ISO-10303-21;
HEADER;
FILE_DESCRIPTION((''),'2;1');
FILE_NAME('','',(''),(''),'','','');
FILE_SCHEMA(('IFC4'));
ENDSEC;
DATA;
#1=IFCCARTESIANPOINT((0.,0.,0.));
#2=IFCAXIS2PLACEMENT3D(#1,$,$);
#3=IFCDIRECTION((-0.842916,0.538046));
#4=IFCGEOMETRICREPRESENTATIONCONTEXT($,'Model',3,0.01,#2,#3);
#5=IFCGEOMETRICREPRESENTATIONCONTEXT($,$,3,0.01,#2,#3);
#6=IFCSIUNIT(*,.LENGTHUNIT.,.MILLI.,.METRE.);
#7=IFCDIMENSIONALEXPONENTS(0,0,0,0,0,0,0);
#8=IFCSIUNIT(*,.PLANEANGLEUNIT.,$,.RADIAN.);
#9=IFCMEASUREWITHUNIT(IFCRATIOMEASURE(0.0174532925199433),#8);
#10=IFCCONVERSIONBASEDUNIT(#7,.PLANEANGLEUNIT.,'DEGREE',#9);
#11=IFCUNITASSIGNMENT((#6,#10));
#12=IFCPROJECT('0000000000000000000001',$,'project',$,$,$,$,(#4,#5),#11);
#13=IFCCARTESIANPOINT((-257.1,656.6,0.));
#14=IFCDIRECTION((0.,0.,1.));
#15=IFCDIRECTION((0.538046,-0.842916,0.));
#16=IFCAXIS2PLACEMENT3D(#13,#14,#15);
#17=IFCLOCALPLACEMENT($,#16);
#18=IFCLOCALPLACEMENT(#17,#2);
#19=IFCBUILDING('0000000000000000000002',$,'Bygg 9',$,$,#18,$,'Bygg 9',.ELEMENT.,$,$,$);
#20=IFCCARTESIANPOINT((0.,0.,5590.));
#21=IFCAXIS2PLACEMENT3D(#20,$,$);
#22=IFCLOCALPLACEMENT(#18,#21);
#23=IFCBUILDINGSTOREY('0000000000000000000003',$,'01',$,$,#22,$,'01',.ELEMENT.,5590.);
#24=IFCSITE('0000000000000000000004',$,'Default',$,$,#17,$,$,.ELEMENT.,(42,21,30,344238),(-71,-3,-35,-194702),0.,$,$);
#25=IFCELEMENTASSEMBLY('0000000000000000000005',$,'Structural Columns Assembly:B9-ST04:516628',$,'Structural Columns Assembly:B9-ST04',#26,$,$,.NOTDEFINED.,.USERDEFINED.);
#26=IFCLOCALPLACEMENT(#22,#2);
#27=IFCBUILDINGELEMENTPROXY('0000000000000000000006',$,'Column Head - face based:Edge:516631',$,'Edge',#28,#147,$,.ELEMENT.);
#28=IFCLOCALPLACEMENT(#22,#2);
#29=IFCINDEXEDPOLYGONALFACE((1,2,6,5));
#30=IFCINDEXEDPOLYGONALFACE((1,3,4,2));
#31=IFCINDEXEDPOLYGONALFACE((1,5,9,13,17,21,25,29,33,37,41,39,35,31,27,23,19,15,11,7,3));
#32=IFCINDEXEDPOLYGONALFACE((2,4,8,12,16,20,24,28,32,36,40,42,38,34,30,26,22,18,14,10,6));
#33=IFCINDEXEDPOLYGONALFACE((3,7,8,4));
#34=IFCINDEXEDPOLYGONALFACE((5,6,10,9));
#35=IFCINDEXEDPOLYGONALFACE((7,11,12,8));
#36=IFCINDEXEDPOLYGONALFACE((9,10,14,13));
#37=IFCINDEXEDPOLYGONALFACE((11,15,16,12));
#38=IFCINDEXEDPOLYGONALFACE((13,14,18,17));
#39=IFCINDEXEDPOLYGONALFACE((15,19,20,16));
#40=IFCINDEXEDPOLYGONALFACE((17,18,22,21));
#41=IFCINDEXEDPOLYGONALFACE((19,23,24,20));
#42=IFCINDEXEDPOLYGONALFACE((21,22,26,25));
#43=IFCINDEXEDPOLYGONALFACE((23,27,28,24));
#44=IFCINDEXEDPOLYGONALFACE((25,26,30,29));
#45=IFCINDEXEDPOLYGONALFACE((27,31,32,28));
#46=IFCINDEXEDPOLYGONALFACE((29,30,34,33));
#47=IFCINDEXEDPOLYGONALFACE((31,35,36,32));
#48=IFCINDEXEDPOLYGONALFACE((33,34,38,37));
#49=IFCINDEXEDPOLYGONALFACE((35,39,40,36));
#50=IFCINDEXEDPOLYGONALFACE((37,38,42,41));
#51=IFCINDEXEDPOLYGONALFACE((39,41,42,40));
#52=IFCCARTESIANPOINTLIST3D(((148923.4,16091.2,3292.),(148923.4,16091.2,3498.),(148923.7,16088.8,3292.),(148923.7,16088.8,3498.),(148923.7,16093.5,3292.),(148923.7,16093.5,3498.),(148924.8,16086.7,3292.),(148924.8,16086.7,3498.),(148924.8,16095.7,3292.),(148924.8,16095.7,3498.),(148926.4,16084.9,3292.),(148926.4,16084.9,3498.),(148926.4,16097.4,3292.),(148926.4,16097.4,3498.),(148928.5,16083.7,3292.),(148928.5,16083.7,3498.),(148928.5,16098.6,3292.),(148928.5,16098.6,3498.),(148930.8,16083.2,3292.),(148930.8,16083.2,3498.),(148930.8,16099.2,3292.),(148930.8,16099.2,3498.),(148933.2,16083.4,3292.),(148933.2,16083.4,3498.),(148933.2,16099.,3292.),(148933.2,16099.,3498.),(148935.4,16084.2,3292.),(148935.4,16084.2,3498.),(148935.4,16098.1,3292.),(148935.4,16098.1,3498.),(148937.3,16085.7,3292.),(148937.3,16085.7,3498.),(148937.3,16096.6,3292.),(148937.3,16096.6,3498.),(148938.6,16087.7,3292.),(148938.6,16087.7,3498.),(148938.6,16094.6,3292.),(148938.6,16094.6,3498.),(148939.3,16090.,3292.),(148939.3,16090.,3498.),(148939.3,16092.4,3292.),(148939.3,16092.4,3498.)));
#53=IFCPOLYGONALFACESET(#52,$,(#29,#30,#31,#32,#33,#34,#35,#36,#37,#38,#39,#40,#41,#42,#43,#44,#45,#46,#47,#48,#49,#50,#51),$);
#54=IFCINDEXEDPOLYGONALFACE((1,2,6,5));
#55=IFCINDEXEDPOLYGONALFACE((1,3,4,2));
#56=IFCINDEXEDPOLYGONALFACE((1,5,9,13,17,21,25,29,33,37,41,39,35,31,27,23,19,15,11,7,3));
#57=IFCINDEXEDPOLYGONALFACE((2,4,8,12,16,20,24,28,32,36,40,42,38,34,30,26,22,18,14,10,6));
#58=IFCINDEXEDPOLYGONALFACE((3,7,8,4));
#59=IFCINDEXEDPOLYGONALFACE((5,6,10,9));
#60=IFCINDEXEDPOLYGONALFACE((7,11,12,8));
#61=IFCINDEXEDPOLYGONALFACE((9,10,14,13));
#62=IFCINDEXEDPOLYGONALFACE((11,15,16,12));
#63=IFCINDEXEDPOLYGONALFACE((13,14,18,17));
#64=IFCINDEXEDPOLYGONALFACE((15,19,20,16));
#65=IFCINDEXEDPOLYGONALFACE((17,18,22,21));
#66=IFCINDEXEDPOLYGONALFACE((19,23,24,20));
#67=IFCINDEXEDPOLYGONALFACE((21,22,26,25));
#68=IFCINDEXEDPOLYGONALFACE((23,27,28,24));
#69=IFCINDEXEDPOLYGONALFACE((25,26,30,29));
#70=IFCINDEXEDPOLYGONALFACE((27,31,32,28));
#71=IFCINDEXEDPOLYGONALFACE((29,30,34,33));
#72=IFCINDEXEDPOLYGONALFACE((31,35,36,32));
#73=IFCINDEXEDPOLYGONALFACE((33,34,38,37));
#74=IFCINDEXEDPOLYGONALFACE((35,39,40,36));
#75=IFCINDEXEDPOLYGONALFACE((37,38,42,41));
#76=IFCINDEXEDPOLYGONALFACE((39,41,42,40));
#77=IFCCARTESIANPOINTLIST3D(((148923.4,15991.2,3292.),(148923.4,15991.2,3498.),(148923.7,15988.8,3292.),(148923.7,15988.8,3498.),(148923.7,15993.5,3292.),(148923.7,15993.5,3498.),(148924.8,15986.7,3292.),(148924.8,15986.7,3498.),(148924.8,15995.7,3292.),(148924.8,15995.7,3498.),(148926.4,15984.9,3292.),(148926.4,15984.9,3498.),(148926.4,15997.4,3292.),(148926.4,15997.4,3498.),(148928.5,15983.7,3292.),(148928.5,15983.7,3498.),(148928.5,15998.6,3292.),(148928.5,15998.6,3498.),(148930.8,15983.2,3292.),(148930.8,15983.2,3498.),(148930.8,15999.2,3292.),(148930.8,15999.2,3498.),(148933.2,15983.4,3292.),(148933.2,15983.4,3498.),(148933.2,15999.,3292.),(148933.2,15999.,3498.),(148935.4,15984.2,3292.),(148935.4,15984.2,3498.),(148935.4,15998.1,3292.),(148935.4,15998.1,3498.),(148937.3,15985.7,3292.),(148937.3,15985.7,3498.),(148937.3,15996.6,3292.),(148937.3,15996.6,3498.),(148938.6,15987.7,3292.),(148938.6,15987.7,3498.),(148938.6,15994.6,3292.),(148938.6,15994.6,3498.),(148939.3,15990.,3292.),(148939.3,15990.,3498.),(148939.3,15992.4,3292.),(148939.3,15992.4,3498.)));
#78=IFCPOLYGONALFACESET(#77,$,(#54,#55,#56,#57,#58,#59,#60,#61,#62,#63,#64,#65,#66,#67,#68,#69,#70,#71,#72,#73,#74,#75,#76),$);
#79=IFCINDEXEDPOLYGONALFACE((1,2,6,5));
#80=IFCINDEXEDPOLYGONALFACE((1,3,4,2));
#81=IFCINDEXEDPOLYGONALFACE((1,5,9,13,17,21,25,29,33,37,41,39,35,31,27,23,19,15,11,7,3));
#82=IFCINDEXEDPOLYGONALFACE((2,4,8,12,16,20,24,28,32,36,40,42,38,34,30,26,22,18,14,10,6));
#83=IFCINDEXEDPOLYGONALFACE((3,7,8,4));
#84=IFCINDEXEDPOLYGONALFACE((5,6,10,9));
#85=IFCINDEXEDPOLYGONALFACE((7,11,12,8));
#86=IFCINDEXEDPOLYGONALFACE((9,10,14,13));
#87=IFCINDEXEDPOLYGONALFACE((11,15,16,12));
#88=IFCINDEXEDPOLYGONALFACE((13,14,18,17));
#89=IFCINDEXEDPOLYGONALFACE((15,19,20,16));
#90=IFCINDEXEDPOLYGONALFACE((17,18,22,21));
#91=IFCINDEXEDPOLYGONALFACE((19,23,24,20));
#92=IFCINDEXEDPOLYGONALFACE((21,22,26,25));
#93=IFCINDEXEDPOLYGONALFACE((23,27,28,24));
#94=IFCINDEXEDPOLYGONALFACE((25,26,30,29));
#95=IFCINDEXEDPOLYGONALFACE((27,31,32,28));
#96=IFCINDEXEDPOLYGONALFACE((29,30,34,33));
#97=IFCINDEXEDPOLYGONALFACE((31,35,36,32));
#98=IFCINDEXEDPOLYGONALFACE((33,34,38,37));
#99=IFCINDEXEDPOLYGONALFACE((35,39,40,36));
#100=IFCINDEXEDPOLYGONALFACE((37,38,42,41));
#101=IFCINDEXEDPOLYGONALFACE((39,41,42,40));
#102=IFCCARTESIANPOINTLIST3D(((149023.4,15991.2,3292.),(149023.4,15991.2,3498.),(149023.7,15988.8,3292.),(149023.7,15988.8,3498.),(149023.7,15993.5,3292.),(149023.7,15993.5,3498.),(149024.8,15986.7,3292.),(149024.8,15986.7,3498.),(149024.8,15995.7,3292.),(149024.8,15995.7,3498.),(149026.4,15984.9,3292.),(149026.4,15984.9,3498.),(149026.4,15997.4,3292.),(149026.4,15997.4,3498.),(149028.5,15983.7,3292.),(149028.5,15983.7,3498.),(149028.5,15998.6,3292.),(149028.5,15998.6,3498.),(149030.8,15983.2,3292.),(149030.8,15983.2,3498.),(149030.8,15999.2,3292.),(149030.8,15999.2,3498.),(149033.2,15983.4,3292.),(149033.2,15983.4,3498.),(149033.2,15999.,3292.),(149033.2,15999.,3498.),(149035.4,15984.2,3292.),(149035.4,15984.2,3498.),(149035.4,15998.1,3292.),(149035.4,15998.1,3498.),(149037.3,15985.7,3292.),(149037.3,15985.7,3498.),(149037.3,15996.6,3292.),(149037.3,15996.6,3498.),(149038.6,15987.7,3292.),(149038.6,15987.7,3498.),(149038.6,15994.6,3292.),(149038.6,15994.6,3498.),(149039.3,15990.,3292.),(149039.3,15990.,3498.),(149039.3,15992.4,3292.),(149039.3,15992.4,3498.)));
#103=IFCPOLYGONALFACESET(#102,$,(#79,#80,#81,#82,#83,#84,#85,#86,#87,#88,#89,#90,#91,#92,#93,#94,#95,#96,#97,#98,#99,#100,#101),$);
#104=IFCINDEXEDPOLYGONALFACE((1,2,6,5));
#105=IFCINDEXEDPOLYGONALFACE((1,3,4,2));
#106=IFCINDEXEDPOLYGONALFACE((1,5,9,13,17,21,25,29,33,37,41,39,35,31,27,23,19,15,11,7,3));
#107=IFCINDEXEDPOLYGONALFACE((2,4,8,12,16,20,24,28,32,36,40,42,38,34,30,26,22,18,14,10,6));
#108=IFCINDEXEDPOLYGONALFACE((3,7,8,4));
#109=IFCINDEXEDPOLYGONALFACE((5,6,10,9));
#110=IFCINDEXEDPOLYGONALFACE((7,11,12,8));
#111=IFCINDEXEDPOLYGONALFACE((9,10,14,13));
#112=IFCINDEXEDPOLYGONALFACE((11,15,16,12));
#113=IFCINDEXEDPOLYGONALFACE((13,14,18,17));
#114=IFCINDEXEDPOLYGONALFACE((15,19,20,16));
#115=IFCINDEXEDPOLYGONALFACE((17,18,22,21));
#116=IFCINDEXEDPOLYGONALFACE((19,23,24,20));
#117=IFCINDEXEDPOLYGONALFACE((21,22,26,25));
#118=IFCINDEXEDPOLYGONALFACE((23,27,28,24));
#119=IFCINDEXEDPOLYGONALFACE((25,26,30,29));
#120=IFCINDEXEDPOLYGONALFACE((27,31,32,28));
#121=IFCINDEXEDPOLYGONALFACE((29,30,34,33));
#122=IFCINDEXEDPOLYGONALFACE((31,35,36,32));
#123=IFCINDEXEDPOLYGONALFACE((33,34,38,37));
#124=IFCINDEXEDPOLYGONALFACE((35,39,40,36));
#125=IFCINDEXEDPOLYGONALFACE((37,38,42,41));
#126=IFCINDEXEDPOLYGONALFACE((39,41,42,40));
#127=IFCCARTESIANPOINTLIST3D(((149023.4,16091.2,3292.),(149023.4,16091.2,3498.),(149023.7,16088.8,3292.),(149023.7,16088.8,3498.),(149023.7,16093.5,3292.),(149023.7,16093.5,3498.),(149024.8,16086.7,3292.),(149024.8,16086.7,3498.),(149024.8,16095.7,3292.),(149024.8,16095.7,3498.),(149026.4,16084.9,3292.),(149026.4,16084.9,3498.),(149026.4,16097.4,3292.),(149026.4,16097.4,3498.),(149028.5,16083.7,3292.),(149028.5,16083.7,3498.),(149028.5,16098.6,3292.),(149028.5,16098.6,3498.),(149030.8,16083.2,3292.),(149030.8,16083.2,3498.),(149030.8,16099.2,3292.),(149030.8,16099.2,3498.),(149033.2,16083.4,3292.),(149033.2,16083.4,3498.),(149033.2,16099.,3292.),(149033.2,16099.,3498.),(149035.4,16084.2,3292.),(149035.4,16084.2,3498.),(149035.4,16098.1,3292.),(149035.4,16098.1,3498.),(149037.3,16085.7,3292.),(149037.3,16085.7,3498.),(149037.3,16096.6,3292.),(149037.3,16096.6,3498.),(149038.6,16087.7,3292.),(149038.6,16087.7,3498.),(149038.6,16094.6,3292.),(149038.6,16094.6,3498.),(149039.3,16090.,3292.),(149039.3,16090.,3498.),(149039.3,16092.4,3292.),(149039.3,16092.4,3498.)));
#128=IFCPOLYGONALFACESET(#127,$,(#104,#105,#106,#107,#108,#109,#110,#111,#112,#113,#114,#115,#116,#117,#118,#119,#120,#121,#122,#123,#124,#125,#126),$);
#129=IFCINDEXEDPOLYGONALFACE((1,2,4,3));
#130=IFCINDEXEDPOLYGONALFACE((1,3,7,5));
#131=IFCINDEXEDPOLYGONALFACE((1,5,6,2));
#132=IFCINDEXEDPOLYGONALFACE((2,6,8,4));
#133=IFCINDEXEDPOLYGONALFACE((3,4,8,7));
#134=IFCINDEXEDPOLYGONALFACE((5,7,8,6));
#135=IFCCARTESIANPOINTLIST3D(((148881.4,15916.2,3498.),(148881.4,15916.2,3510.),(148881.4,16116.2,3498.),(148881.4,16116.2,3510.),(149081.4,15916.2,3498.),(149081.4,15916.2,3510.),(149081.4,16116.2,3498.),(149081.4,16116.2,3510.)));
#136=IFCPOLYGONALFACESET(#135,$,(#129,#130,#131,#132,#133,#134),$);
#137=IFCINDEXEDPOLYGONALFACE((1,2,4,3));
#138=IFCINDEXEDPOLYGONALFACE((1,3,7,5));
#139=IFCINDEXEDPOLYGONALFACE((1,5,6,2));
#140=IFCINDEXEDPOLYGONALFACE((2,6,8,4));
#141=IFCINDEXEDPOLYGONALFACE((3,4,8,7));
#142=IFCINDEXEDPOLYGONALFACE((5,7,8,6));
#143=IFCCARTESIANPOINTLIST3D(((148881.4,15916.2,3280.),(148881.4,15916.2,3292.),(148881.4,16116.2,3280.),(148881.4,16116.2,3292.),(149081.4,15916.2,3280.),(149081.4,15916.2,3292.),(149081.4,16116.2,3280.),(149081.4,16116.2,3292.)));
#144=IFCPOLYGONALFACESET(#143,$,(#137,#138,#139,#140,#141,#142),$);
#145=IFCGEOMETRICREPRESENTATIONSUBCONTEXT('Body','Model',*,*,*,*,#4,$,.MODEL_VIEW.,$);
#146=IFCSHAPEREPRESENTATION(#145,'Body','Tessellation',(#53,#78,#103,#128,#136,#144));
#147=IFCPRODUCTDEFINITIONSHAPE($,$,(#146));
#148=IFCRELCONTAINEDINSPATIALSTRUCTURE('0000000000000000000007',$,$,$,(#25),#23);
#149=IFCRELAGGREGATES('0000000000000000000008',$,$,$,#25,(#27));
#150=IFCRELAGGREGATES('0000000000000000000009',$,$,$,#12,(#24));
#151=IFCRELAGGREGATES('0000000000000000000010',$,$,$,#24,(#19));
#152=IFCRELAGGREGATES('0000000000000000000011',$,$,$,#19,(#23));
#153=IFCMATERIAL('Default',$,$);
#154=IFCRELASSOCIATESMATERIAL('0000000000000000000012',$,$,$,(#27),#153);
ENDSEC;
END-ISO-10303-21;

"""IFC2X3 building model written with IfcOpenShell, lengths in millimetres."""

from ifc_helpers import new_model, entity, si_unit, converted_unit, direction, frame, frame_2d, origin, origin_2d_with_axis, place, context, subcontext, project, spatial, rectangle, circle, extrude, source, transform, mapped, material, element, aggregate, save


model = new_model("IFC2X3")

# Units and contexts
model_context = context("Model", 3, precision=0.01, world=origin(), true_north=direction((-0.842916, 0.538046)))
context_of_model = context(None, 3, precision=0.01, world=origin(), true_north=direction((-0.842916, 0.538046)))
body_context = subcontext(model_context, "Body", "Model", "MODEL_VIEW")
ifc_project = project(units=[si_unit("LENGTHUNIT", "METRE", prefix="MILLI"), converted_unit("PLANEANGLEUNIT", "DEGREE", entity("IfcRatioMeasure", 0.0174532925199433), si_unit("PLANEANGLEUNIT", "RADIAN"), dimensions=[0, 0, 0, 0, 0, 0, 0])], contexts=[model_context, context_of_model])

# Site, building, storey
site_placement = place(None, frame((-257.1, 656.6, 0.0), z_axis=(0.0, 0.0, 1.0), x_axis=(0.538046, -0.842916, 0.0)))
site = spatial("IfcSite", under=ifc_project, at=site_placement, Name="Default", CompositionType="ELEMENT", RefLatitude=(42, 21, 30, 344238), RefLongitude=(-71, -3, -35, -194702), RefElevation=0.0)
building_placement = place(site_placement, origin())
building = spatial("IfcBuilding", under=site, at=building_placement, Name="Bygg 9", LongName="Bygg 9", CompositionType="ELEMENT")
storey_placement = place(building_placement, frame((0.0, 0.0, 5590.0)))
storey = spatial("IfcBuildingStorey", under=building, at=storey_placement, Name="01", LongName="01", CompositionType="ELEMENT", Elevation=5590.0)

# Element assembly
assembly_1_placement = place(storey_placement, origin())
assembly_1 = element("IfcElementAssembly", 1, at=assembly_1_placement, inside=storey, Name="Structural Columns Assembly:B9-ST04:516628", ObjectType="Structural Columns Assembly:B9-ST04", AssemblyPlace="NOTDEFINED", PredefinedType="USERDEFINED")

# Building element proxy
ifc_material_1 = material(Name="Default")
shared_shape_1 = source(origin(), body_context, "Body", "SweptSolid", [
    extrude(circle(Radius=8.0, at=frame_2d((0.0, 0.0), x_axis=(1.0, 0.0))), frame((50.0, -75.0, 12.0)), (0.0, 0.0, 1.0), 206.0),
    extrude(circle(Radius=8.0, at=frame_2d((0.0, 0.0), x_axis=(1.0, 0.0))), frame((50.0, 25.0, 12.0)), (0.0, 0.0, 1.0), 206.0),
    extrude(circle(Radius=8.0, at=frame_2d((0.0, 0.0), x_axis=(1.0, 0.0))), frame((-50.0, 25.0, 12.0)), (0.0, 0.0, 1.0), 206.0),
    extrude(circle(Radius=8.0, at=frame_2d((0.0, 0.0), x_axis=(1.0, 0.0))), frame((-50.0, -75.0, 12.0)), (0.0, 0.0, 1.0), 206.0),
    extrude(rectangle(XDim=200.0, YDim=200.0, at=origin_2d_with_axis()), frame((0.0, 0.0, 218.0), z_axis=(0.0, 0.0, 1.0), x_axis=(-1.0, 0.0, 0.0)), (0.0, 0.0, 1.0), 12.0),
    extrude(rectangle(XDim=200.0, YDim=200.0, at=origin_2d_with_axis()), frame((0.0, 0.0, 0.0), z_axis=(0.0, 0.0, 1.0), x_axis=(0.0, 1.0, 0.0)), (0.0, 0.0, 1.0), 12.0),
])
proxy_1_placement = place(assembly_1_placement, frame((148981.4, 16016.2, 3280.0), z_axis=(0.0, 0.0, 1.0), x_axis=(-1.0, 0.0, 0.0)))
proxy_1 = element("IfcBuildingElementProxy", 2, at=proxy_1_placement, material=ifc_material_1, Name="Column Head - face based:Edge:516631", ObjectType="Edge", CompositionType="ELEMENT", context=body_context, shape_type="MappedRepresentation", body=[
    mapped(shared_shape_1, transform((0.0, 0.0, 0.0), scale=1.0)),
])
aggregate(assembly_1, [proxy_1])

save(model, "model.ifc")
